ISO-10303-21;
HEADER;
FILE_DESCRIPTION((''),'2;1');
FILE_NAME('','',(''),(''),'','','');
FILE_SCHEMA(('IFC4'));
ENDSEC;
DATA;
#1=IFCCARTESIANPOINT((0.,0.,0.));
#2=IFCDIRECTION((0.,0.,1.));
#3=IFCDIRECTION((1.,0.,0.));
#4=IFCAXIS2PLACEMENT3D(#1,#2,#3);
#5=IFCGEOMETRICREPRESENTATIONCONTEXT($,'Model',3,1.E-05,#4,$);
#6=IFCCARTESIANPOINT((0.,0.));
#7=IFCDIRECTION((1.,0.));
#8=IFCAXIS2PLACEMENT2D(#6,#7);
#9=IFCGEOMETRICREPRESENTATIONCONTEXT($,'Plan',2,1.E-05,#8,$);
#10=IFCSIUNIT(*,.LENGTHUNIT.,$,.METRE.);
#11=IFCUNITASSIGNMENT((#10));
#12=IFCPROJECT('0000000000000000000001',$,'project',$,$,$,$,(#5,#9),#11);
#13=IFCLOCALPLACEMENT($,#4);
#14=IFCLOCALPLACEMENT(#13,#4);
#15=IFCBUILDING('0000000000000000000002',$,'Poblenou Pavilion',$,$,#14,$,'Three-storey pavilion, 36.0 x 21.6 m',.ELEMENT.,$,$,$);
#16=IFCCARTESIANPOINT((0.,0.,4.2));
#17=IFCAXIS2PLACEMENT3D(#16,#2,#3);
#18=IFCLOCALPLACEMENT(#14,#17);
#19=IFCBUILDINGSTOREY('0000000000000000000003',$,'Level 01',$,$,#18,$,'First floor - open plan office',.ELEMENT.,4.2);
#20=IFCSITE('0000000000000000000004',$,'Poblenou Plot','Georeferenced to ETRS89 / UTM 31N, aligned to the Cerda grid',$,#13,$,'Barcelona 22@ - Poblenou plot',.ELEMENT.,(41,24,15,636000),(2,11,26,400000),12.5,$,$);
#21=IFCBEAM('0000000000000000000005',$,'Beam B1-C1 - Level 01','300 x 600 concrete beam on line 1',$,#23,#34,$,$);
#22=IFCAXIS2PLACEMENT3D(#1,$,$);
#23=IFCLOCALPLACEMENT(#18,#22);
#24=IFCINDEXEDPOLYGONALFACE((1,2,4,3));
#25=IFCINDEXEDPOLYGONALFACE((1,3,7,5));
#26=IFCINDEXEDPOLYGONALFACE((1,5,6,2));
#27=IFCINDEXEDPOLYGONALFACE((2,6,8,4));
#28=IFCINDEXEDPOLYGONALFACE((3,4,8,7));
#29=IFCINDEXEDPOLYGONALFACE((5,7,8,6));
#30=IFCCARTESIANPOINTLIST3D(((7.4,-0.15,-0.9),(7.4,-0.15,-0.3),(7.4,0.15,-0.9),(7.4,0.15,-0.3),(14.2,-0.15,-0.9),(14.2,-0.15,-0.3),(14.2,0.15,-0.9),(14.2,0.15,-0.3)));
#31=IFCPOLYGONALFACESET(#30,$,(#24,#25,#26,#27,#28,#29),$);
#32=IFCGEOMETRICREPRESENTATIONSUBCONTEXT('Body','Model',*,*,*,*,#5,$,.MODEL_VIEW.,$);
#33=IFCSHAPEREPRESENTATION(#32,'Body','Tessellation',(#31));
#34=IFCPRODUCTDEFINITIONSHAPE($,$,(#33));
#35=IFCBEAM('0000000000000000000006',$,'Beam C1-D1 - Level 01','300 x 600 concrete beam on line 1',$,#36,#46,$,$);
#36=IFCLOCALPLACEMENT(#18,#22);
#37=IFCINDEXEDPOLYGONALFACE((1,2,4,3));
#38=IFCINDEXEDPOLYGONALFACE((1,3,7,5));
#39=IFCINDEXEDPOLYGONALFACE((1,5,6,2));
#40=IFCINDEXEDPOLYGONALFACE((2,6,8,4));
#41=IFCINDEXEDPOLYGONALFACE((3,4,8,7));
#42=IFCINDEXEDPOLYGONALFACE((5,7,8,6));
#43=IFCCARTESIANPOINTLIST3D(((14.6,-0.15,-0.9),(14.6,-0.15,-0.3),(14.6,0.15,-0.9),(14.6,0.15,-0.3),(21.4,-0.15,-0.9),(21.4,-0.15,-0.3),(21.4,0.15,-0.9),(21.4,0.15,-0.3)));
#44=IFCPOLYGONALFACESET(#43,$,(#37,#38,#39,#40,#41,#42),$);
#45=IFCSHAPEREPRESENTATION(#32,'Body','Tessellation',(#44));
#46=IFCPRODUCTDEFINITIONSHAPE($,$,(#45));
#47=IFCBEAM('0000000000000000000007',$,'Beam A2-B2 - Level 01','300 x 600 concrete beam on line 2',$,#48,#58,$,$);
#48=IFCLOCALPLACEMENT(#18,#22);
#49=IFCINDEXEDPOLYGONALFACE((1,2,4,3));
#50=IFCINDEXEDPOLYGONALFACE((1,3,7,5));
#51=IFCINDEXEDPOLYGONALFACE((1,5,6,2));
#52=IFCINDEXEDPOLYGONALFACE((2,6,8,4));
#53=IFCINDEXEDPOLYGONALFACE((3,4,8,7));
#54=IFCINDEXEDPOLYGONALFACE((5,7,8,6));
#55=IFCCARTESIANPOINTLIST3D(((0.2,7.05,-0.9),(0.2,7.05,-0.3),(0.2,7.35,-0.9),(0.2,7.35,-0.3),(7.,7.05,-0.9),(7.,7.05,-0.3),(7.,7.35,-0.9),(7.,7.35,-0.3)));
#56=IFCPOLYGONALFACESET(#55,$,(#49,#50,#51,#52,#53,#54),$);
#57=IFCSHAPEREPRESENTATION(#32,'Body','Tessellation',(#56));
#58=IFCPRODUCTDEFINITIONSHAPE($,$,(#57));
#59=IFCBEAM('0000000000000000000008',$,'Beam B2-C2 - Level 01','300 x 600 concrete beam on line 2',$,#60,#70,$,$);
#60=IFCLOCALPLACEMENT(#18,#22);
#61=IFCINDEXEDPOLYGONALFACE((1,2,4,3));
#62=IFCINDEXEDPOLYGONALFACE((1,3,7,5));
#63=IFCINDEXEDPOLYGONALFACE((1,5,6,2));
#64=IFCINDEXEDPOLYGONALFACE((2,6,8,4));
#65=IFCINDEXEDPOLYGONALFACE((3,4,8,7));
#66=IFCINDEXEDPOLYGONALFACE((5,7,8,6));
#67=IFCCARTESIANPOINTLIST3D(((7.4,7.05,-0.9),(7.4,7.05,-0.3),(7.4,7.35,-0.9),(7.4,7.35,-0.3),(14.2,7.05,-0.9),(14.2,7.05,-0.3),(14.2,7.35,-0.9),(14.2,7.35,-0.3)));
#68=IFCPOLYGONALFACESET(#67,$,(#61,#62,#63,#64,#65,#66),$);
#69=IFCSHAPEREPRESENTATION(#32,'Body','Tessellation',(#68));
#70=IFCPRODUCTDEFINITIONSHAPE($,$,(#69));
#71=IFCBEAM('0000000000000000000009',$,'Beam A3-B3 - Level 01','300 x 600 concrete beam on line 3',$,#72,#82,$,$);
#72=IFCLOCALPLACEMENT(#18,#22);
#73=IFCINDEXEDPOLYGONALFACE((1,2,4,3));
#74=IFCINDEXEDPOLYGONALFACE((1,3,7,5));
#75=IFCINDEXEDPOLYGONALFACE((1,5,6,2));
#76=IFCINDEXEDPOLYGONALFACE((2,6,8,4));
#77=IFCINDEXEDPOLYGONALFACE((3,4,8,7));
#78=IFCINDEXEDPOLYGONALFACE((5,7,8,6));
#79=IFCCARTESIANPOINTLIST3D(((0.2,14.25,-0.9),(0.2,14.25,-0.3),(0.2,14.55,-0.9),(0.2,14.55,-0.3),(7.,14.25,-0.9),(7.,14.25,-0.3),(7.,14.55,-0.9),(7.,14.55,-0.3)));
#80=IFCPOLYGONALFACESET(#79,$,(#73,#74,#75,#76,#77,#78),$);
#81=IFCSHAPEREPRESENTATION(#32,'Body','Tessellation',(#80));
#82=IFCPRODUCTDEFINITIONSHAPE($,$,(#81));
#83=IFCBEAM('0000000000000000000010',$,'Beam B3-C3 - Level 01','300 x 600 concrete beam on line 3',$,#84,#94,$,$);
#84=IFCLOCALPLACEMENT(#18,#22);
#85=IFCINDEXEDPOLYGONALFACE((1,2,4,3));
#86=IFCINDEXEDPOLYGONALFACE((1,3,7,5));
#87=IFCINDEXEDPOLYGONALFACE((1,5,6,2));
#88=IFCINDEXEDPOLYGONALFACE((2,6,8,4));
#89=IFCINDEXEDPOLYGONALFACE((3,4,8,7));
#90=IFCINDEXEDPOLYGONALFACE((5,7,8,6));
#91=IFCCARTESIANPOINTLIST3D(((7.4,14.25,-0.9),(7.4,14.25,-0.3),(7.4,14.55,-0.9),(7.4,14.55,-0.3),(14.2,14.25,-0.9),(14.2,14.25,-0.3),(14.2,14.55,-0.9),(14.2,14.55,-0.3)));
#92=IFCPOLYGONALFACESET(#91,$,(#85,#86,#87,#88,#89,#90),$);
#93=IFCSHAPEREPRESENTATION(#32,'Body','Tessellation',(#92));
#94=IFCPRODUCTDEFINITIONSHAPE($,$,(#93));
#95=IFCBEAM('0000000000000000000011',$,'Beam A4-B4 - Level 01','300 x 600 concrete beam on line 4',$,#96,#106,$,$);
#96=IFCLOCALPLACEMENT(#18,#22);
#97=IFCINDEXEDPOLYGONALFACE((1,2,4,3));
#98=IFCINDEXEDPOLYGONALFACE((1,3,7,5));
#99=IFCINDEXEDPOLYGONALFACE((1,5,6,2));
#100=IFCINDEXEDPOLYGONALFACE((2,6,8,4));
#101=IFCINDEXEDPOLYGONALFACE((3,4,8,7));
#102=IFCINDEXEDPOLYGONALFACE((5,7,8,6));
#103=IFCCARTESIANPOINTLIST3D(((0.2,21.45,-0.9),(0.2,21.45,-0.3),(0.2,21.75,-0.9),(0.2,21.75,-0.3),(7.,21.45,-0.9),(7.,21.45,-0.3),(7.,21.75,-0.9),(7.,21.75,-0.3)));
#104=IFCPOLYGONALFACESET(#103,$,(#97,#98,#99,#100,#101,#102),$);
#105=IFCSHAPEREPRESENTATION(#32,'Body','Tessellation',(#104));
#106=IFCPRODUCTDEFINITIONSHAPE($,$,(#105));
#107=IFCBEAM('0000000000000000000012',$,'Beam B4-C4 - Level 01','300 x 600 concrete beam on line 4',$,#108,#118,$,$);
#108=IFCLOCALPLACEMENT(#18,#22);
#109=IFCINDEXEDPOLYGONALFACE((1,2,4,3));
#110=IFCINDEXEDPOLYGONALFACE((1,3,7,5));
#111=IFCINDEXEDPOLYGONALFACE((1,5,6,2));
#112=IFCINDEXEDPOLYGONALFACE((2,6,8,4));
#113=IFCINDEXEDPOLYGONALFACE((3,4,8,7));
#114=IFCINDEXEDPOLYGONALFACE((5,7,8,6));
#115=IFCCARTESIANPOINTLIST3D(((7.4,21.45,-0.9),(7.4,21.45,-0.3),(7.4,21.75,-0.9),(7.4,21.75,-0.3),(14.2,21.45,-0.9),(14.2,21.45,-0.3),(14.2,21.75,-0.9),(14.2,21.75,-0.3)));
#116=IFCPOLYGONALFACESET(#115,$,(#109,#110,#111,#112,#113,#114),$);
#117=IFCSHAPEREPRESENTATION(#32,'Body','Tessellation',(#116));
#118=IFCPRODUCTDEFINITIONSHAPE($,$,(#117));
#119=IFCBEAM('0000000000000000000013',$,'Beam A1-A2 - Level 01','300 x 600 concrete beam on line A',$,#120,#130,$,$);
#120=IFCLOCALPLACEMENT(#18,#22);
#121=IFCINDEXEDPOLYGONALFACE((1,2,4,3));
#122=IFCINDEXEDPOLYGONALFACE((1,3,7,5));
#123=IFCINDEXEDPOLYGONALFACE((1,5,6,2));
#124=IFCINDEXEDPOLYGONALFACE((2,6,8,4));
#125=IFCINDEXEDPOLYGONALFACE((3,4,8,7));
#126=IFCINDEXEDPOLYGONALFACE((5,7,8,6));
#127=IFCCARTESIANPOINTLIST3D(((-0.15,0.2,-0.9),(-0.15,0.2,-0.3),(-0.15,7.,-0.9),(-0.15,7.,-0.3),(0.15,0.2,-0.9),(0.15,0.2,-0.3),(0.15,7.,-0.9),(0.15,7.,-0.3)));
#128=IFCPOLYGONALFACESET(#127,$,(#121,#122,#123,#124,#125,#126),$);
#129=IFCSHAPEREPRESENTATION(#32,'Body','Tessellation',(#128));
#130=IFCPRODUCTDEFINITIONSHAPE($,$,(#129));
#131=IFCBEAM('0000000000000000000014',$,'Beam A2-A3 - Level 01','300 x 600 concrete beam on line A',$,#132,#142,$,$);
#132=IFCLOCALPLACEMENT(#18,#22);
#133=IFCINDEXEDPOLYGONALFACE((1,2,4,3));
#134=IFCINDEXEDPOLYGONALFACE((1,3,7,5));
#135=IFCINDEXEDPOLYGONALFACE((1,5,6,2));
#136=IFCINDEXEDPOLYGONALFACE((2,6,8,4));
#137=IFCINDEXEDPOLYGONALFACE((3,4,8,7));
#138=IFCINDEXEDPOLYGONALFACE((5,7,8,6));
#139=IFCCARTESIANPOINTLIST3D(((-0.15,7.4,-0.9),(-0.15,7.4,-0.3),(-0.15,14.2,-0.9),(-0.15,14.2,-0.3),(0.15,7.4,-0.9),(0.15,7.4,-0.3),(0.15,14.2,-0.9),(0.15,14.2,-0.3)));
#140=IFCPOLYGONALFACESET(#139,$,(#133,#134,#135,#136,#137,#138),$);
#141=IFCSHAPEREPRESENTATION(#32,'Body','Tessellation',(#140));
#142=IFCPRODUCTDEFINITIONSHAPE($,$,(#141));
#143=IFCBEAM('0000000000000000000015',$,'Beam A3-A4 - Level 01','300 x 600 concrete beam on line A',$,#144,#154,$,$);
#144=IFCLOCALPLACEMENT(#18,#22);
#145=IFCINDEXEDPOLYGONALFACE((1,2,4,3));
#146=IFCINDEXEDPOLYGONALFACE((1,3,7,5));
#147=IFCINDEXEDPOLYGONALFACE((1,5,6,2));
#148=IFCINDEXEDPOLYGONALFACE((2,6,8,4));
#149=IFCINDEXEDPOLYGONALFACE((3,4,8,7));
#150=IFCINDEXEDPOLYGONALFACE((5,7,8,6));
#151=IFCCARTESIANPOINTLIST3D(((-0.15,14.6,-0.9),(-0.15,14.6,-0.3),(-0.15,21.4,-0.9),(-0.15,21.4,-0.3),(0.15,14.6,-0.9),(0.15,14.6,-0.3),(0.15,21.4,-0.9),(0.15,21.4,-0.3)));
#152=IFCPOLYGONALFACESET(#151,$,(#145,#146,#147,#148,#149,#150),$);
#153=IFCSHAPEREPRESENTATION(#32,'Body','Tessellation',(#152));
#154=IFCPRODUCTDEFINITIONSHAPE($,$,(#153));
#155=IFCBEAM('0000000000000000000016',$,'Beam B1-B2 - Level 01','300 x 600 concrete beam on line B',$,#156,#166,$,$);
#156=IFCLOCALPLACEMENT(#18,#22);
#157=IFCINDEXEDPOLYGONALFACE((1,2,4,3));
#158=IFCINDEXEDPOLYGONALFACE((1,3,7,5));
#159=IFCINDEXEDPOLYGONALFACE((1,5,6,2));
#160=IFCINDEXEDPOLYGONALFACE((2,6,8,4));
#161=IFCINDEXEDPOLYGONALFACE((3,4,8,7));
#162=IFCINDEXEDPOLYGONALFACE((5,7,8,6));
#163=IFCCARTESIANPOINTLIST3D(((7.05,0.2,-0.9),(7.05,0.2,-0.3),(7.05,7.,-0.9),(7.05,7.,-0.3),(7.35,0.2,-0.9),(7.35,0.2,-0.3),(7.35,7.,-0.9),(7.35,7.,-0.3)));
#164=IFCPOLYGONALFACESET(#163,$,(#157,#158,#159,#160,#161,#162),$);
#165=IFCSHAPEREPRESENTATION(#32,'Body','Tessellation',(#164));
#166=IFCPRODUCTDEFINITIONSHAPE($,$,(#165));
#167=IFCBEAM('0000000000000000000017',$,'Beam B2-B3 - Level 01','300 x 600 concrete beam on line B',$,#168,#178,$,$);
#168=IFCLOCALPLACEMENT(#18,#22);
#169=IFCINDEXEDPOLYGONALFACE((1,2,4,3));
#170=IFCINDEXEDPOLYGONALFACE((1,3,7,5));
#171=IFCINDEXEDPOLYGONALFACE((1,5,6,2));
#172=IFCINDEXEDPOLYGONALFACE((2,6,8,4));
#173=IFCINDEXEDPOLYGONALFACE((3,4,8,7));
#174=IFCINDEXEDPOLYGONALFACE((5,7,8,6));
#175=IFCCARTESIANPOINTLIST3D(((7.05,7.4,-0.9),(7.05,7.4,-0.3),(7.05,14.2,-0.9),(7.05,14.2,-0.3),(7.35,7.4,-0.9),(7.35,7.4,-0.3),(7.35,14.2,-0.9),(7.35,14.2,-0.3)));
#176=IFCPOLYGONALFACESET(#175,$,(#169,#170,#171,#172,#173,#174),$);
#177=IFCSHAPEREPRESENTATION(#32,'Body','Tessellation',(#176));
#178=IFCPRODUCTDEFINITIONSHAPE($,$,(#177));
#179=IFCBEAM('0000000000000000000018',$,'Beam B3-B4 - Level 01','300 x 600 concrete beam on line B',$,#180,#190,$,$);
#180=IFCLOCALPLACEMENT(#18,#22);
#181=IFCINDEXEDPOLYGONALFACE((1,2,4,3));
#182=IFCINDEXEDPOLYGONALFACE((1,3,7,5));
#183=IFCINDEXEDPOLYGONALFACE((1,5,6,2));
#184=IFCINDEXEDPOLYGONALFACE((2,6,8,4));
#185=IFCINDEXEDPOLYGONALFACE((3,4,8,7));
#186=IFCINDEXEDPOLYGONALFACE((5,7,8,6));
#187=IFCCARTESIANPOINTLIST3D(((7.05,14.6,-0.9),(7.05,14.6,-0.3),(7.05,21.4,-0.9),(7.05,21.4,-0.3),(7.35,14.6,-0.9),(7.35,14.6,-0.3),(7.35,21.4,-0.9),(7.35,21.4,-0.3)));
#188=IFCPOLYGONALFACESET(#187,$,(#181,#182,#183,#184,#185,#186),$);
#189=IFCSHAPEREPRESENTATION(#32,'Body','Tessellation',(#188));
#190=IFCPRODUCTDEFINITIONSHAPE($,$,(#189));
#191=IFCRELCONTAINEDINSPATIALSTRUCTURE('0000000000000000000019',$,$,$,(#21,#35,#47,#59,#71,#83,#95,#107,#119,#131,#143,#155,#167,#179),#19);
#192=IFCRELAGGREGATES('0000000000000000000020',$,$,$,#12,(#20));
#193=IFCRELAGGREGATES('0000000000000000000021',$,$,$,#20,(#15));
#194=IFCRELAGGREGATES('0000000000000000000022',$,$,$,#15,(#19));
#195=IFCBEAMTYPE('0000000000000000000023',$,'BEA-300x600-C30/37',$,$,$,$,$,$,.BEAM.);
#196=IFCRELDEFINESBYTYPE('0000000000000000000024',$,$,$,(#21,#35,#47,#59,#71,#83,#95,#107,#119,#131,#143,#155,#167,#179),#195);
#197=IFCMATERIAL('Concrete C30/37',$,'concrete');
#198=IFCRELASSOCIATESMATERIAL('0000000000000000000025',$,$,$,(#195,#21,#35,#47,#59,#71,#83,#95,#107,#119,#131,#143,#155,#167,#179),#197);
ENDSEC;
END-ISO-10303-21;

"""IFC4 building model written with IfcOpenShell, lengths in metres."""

from ifc_helpers import new_model, si_unit, frame, origin_with_axes, origin_2d_with_axis, place, context, subcontext, project, spatial, line, indexed_curve, rectangle, outline, extrude, material, material_profile, profile_set, profile_usage, type_object, element, save


model = new_model("IFC4")

# Units and contexts
model_context = context("Model", 3, precision=1e-05, world=origin_with_axes())
plan_context = context("Plan", 2, precision=1e-05, world=origin_2d_with_axis())
body_context = subcontext(model_context, "Body", "Model", "MODEL_VIEW")
ifc_project = project(units=[si_unit("LENGTHUNIT", "METRE")], contexts=[model_context, plan_context])

# Site, building, storey
site_placement = place(None, origin_with_axes())
site = spatial("IfcSite", under=ifc_project, at=site_placement, Name="Poblenou Plot", Description="Georeferenced to ETRS89 / UTM 31N, aligned to the Cerda grid", LongName="Barcelona 22@ - Poblenou plot", CompositionType="ELEMENT", RefLatitude=(41, 24, 15, 636000), RefLongitude=(2, 11, 26, 400000), RefElevation=12.5)
building_placement = place(site_placement, origin_with_axes())
building = spatial("IfcBuilding", under=site, at=building_placement, Name="Poblenou Pavilion", LongName="Three-storey pavilion, 36.0 x 21.6 m", CompositionType="ELEMENT")
storey_placement = place(building_placement, frame((0.0, 0.0, 4.2), z_axis=(0.0, 0.0, 1.0), x_axis=(1.0, 0.0, 0.0)))
storey = spatial("IfcBuildingStorey", under=building, at=storey_placement, Name="Level 01", LongName="First floor - open plan office", CompositionType="ELEMENT", Elevation=4.2)

# Shared definitions
ifc_material = material(Name="Concrete C30/37", Category="concrete")

# Beams
ifc_material_profile_1 = material_profile(ifc_material, rectangle(XDim=0.3, YDim=0.6))
ifc_profile_set_1 = profile_set([ifc_material_profile_1], Name="BEA-300x600-C30/37")
beam_type = type_object("IfcBeamType", Name="BEA-300x600-C30/37", PredefinedType="BEAM", material=ifc_profile_set_1)
ifc_profile_usage_1 = profile_usage(ifc_profile_set_1)
beam_1_placement = place(storey_placement, frame((7.4, -0.15, -0.9), z_axis=(1.0, 0.0, 0.0), x_axis=(0.0, 1.0, 0.0)))
element("IfcBeam", 1, at=beam_1_placement, inside=storey, type_object=beam_type, material=ifc_profile_usage_1, Name="Beam B1-C1 - Level 01", Description="300 x 600 concrete beam on line 1", context=body_context, shape_type="SweptSolid", body=[
    extrude(outline(indexed_curve([(0.0, 0.0), (0.3, 0.0), (0.3, 0.6), (0.0, 0.6)], segments=[line(1, 2, 3, 4, 1)])), origin_with_axes(), (0.0, 0.0, 1.0), 6.8),
])
ifc_profile_usage_2 = profile_usage(ifc_profile_set_1)
beam_2_placement = place(storey_placement, frame((14.6, -0.15, -0.9), z_axis=(1.0, 0.0, 0.0), x_axis=(0.0, 1.0, 0.0)))
element("IfcBeam", 2, at=beam_2_placement, inside=storey, type_object=beam_type, material=ifc_profile_usage_2, Name="Beam C1-D1 - Level 01", Description="300 x 600 concrete beam on line 1", context=body_context, shape_type="SweptSolid", body=[
    extrude(outline(indexed_curve([(0.0, 0.0), (0.3, 0.0), (0.3, 0.6), (0.0, 0.6)], segments=[line(1, 2, 3, 4, 1)])), origin_with_axes(), (0.0, 0.0, 1.0), 6.8),
])
ifc_profile_usage_3 = profile_usage(ifc_profile_set_1)
beam_3_placement = place(storey_placement, frame((0.2, 7.05, -0.9), z_axis=(1.0, 0.0, 0.0), x_axis=(0.0, 1.0, 0.0)))
element("IfcBeam", 3, at=beam_3_placement, inside=storey, type_object=beam_type, material=ifc_profile_usage_3, Name="Beam A2-B2 - Level 01", Description="300 x 600 concrete beam on line 2", context=body_context, shape_type="SweptSolid", body=[
    extrude(outline(indexed_curve([(0.0, 0.0), (0.3, 0.0), (0.3, 0.6), (0.0, 0.6)], segments=[line(1, 2, 3, 4, 1)])), origin_with_axes(), (0.0, 0.0, 1.0), 6.8),
])
ifc_profile_usage_4 = profile_usage(ifc_profile_set_1)
beam_4_placement = place(storey_placement, frame((7.4, 7.05, -0.9), z_axis=(1.0, 0.0, 0.0), x_axis=(0.0, 1.0, 0.0)))
element("IfcBeam", 4, at=beam_4_placement, inside=storey, type_object=beam_type, material=ifc_profile_usage_4, Name="Beam B2-C2 - Level 01", Description="300 x 600 concrete beam on line 2", context=body_context, shape_type="SweptSolid", body=[
    extrude(outline(indexed_curve([(0.0, 0.0), (0.3, 0.0), (0.3, 0.6), (0.0, 0.6)], segments=[line(1, 2, 3, 4, 1)])), origin_with_axes(), (0.0, 0.0, 1.0), 6.8),
])
ifc_profile_usage_5 = profile_usage(ifc_profile_set_1)
beam_5_placement = place(storey_placement, frame((0.2, 14.25, -0.9), z_axis=(1.0, 0.0, 0.0), x_axis=(0.0, 1.0, 0.0)))
element("IfcBeam", 5, at=beam_5_placement, inside=storey, type_object=beam_type, material=ifc_profile_usage_5, Name="Beam A3-B3 - Level 01", Description="300 x 600 concrete beam on line 3", context=body_context, shape_type="SweptSolid", body=[
    extrude(outline(indexed_curve([(0.0, 0.0), (0.3, 0.0), (0.3, 0.6), (0.0, 0.6)], segments=[line(1, 2, 3, 4, 1)])), origin_with_axes(), (0.0, 0.0, 1.0), 6.8),
])
ifc_profile_usage_6 = profile_usage(ifc_profile_set_1)
beam_6_placement = place(storey_placement, frame((7.4, 14.25, -0.9), z_axis=(1.0, 0.0, 0.0), x_axis=(0.0, 1.0, 0.0)))
element("IfcBeam", 6, at=beam_6_placement, inside=storey, type_object=beam_type, material=ifc_profile_usage_6, Name="Beam B3-C3 - Level 01", Description="300 x 600 concrete beam on line 3", context=body_context, shape_type="SweptSolid", body=[
    extrude(outline(indexed_curve([(0.0, 0.0), (0.3, 0.0), (0.3, 0.6), (0.0, 0.6)], segments=[line(1, 2, 3, 4, 1)])), origin_with_axes(), (0.0, 0.0, 1.0), 6.8),
])
ifc_profile_usage_7 = profile_usage(ifc_profile_set_1)
beam_7_placement = place(storey_placement, frame((0.2, 21.45, -0.9), z_axis=(1.0, 0.0, 0.0), x_axis=(0.0, 1.0, 0.0)))
element("IfcBeam", 7, at=beam_7_placement, inside=storey, type_object=beam_type, material=ifc_profile_usage_7, Name="Beam A4-B4 - Level 01", Description="300 x 600 concrete beam on line 4", context=body_context, shape_type="SweptSolid", body=[
    extrude(outline(indexed_curve([(0.0, 0.0), (0.3, 0.0), (0.3, 0.6), (0.0, 0.6)], segments=[line(1, 2, 3, 4, 1)])), origin_with_axes(), (0.0, 0.0, 1.0), 6.8),
])
ifc_profile_usage_8 = profile_usage(ifc_profile_set_1)
beam_8_placement = place(storey_placement, frame((7.4, 21.45, -0.9), z_axis=(1.0, 0.0, 0.0), x_axis=(0.0, 1.0, 0.0)))
element("IfcBeam", 8, at=beam_8_placement, inside=storey, type_object=beam_type, material=ifc_profile_usage_8, Name="Beam B4-C4 - Level 01", Description="300 x 600 concrete beam on line 4", context=body_context, shape_type="SweptSolid", body=[
    extrude(outline(indexed_curve([(0.0, 0.0), (0.3, 0.0), (0.3, 0.6), (0.0, 0.6)], segments=[line(1, 2, 3, 4, 1)])), origin_with_axes(), (0.0, 0.0, 1.0), 6.8),
])
ifc_profile_usage_9 = profile_usage(ifc_profile_set_1)
beam_9_placement = place(storey_placement, frame((-0.15, 0.2, -0.9), z_axis=(0.0, 1.0, 0.0), x_axis=(0.0, 0.0, 1.0)))
element("IfcBeam", 9, at=beam_9_placement, inside=storey, type_object=beam_type, material=ifc_profile_usage_9, Name="Beam A1-A2 - Level 01", Description="300 x 600 concrete beam on line A", context=body_context, shape_type="SweptSolid", body=[
    extrude(outline(indexed_curve([(0.0, 0.0), (0.6, 0.0), (0.6, 0.3), (0.0, 0.3)], segments=[line(1, 2, 3, 4, 1)])), origin_with_axes(), (0.0, 0.0, 1.0), 6.8),
])
ifc_profile_usage_10 = profile_usage(ifc_profile_set_1)
beam_10_placement = place(storey_placement, frame((-0.15, 7.4, -0.9), z_axis=(0.0, 1.0, 0.0), x_axis=(0.0, 0.0, 1.0)))
element("IfcBeam", 10, at=beam_10_placement, inside=storey, type_object=beam_type, material=ifc_profile_usage_10, Name="Beam A2-A3 - Level 01", Description="300 x 600 concrete beam on line A", context=body_context, shape_type="SweptSolid", body=[
    extrude(outline(indexed_curve([(0.0, 0.0), (0.6, 0.0), (0.6, 0.3), (0.0, 0.3)], segments=[line(1, 2, 3, 4, 1)])), origin_with_axes(), (0.0, 0.0, 1.0), 6.8),
])
ifc_profile_usage_11 = profile_usage(ifc_profile_set_1)
beam_11_placement = place(storey_placement, frame((-0.15, 14.6, -0.9), z_axis=(0.0, 1.0, 0.0), x_axis=(0.0, 0.0, 1.0)))
element("IfcBeam", 11, at=beam_11_placement, inside=storey, type_object=beam_type, material=ifc_profile_usage_11, Name="Beam A3-A4 - Level 01", Description="300 x 600 concrete beam on line A", context=body_context, shape_type="SweptSolid", body=[
    extrude(outline(indexed_curve([(0.0, 0.0), (0.6, 0.0), (0.6, 0.3), (0.0, 0.3)], segments=[line(1, 2, 3, 4, 1)])), origin_with_axes(), (0.0, 0.0, 1.0), 6.8),
])
ifc_profile_usage_12 = profile_usage(ifc_profile_set_1)
beam_12_placement = place(storey_placement, frame((7.05, 0.2, -0.9), z_axis=(0.0, 1.0, 0.0), x_axis=(0.0, 0.0, 1.0)))
element("IfcBeam", 12, at=beam_12_placement, inside=storey, type_object=beam_type, material=ifc_profile_usage_12, Name="Beam B1-B2 - Level 01", Description="300 x 600 concrete beam on line B", context=body_context, shape_type="SweptSolid", body=[
    extrude(outline(indexed_curve([(0.0, 0.0), (0.6, 0.0), (0.6, 0.3), (0.0, 0.3)], segments=[line(1, 2, 3, 4, 1)])), origin_with_axes(), (0.0, 0.0, 1.0), 6.8),
])
ifc_profile_usage_13 = profile_usage(ifc_profile_set_1)
beam_13_placement = place(storey_placement, frame((7.05, 7.4, -0.9), z_axis=(0.0, 1.0, 0.0), x_axis=(0.0, 0.0, 1.0)))
element("IfcBeam", 13, at=beam_13_placement, inside=storey, type_object=beam_type, material=ifc_profile_usage_13, Name="Beam B2-B3 - Level 01", Description="300 x 600 concrete beam on line B", context=body_context, shape_type="SweptSolid", body=[
    extrude(outline(indexed_curve([(0.0, 0.0), (0.6, 0.0), (0.6, 0.3), (0.0, 0.3)], segments=[line(1, 2, 3, 4, 1)])), origin_with_axes(), (0.0, 0.0, 1.0), 6.8),
])
ifc_profile_usage_14 = profile_usage(ifc_profile_set_1)
beam_14_placement = place(storey_placement, frame((7.05, 14.6, -0.9), z_axis=(0.0, 1.0, 0.0), x_axis=(0.0, 0.0, 1.0)))
element("IfcBeam", 14, at=beam_14_placement, inside=storey, type_object=beam_type, material=ifc_profile_usage_14, Name="Beam B3-B4 - Level 01", Description="300 x 600 concrete beam on line B", context=body_context, shape_type="SweptSolid", body=[
    extrude(outline(indexed_curve([(0.0, 0.0), (0.6, 0.0), (0.6, 0.3), (0.0, 0.3)], segments=[line(1, 2, 3, 4, 1)])), origin_with_axes(), (0.0, 0.0, 1.0), 6.8),
])

save(model, "model.ifc")
